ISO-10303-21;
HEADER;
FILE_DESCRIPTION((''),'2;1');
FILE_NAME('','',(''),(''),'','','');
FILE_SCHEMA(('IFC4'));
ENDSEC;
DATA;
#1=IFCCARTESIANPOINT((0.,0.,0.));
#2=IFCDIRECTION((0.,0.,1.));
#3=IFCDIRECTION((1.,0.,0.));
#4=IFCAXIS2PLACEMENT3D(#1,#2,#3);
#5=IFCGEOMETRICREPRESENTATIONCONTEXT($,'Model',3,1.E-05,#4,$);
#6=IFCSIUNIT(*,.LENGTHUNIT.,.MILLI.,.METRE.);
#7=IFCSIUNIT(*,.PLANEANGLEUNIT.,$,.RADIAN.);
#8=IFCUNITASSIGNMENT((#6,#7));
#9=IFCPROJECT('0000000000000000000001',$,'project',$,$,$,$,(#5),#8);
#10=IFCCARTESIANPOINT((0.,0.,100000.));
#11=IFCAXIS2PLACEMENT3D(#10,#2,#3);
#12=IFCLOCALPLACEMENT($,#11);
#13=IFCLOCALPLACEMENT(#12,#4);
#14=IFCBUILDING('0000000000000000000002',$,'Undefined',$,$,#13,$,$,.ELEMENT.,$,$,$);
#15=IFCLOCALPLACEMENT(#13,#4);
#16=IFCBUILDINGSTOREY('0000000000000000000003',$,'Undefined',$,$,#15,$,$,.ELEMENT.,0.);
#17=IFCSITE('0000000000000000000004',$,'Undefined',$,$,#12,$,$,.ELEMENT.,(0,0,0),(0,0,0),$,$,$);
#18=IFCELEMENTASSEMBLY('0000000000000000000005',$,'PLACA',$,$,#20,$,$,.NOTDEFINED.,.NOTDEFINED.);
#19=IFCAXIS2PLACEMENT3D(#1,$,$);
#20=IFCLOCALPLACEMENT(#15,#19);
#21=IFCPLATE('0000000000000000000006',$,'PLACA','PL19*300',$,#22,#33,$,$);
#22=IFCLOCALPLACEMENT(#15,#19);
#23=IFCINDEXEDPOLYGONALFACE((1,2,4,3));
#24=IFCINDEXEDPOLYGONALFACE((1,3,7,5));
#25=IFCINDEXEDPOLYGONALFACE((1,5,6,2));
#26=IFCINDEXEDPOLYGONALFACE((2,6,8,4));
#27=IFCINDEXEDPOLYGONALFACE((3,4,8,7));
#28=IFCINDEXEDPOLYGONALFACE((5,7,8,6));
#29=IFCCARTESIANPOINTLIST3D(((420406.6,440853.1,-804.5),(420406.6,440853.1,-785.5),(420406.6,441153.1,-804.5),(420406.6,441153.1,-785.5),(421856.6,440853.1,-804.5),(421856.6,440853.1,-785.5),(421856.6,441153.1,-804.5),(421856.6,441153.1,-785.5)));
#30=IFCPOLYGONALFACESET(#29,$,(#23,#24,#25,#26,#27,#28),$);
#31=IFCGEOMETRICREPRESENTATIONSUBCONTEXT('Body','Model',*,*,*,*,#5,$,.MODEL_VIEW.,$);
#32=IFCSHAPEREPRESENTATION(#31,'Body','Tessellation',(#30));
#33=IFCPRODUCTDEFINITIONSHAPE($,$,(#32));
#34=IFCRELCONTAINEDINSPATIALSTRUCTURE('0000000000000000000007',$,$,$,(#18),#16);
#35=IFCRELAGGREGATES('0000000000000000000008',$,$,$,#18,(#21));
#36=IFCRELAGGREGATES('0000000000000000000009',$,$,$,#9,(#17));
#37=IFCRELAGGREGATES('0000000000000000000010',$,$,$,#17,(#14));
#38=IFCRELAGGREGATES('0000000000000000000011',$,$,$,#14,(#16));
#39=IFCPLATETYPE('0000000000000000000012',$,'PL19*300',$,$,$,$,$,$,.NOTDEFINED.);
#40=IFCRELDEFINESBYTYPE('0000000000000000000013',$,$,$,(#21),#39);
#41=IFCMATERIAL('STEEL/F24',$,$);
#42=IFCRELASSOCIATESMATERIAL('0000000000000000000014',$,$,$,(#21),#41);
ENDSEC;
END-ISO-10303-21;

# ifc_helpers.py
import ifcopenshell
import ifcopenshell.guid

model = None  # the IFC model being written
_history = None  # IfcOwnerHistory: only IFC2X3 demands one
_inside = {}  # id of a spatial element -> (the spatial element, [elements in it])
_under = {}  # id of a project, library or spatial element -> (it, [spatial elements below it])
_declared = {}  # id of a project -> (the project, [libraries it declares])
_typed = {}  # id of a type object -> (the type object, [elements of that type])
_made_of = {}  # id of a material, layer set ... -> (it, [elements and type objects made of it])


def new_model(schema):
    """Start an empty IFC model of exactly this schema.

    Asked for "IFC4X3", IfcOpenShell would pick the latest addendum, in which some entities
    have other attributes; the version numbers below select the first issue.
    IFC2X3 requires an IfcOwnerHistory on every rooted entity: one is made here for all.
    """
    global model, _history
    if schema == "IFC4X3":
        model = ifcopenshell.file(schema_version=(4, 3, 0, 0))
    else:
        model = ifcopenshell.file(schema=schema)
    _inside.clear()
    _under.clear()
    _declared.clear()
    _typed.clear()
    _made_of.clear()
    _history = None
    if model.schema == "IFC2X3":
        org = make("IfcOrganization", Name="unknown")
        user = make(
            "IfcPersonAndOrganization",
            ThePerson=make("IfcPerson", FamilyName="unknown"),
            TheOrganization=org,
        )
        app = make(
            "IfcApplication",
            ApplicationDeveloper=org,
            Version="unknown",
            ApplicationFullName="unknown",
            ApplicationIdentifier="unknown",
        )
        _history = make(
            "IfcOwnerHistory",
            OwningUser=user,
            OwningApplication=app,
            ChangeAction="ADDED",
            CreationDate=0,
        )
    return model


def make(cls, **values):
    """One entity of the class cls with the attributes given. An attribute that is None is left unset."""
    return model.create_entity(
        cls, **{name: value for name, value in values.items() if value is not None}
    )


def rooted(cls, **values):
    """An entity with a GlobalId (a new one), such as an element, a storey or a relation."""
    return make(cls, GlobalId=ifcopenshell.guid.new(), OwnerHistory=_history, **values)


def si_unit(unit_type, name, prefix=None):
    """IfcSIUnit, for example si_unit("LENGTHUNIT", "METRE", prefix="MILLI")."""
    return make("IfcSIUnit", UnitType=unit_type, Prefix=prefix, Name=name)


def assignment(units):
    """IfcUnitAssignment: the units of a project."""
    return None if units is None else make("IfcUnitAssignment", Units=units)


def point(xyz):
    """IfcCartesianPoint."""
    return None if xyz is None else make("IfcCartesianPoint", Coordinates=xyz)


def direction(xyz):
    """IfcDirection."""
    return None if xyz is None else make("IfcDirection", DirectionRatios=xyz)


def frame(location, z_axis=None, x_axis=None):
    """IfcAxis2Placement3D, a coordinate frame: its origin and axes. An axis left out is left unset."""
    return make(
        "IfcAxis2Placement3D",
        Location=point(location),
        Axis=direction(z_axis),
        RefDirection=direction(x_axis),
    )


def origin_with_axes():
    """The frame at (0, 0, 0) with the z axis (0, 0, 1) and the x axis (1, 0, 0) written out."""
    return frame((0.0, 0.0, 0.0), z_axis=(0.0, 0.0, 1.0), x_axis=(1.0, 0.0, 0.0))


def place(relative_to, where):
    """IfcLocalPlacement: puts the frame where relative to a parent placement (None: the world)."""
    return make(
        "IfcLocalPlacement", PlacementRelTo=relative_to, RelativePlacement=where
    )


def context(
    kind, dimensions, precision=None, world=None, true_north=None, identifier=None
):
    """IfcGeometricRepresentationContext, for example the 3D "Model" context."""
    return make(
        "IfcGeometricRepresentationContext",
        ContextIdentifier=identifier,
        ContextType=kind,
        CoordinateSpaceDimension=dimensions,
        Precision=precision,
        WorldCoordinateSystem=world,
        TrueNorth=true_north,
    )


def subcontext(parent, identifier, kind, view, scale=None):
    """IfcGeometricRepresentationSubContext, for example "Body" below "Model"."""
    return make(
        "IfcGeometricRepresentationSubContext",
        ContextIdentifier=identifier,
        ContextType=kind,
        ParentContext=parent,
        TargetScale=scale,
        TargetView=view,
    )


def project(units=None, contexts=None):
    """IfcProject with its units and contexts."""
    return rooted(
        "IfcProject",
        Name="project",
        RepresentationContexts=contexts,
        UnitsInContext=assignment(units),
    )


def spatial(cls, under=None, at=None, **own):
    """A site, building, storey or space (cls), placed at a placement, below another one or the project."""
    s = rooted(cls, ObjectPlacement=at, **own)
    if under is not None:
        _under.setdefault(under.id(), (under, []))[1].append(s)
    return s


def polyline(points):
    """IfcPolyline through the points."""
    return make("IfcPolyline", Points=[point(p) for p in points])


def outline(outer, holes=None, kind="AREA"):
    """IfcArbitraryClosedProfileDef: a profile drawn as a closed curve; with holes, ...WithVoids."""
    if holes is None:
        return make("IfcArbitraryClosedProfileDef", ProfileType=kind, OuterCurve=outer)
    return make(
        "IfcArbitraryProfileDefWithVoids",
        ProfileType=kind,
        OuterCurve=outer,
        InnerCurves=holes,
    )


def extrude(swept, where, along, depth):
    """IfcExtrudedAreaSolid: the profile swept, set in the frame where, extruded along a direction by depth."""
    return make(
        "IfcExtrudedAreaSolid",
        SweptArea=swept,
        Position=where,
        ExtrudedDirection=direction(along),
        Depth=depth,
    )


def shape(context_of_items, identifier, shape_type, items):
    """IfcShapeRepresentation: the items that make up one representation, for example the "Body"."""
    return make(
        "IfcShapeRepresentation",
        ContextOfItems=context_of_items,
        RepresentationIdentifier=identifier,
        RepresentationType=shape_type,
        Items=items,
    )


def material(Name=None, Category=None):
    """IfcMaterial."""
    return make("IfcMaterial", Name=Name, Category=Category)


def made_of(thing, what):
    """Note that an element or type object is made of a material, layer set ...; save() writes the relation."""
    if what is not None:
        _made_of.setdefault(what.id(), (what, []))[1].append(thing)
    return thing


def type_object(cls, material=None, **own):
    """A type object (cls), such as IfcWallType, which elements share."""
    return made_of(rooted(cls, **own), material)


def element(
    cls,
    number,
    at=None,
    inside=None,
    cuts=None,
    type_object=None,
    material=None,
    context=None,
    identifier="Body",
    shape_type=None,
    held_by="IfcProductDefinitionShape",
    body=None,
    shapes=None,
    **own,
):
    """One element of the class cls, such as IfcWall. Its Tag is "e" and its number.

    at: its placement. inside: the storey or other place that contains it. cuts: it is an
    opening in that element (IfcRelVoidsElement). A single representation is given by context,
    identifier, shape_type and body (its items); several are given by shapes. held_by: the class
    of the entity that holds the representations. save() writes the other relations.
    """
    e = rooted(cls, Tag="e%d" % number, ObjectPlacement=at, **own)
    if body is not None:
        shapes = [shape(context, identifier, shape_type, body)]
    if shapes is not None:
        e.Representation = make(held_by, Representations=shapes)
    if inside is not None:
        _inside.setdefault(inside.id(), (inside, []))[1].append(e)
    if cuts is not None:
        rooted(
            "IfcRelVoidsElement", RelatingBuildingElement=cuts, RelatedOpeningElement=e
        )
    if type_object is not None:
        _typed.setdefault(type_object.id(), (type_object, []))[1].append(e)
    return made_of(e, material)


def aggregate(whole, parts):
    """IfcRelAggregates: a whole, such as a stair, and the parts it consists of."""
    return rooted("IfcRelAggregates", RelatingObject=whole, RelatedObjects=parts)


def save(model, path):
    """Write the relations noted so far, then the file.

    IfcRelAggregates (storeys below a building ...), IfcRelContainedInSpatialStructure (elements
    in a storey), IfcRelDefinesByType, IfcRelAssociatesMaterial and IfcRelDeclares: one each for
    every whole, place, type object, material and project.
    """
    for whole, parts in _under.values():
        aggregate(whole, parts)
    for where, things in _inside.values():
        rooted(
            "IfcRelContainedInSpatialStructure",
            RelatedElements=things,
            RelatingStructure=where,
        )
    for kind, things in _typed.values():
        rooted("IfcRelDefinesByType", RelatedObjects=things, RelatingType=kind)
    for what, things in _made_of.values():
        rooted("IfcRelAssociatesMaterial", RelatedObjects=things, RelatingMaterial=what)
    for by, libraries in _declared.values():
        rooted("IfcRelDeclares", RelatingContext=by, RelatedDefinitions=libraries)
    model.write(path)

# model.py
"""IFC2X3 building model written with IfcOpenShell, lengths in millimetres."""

from ifc_helpers import new_model, si_unit, frame, origin_with_axes, place, context, subcontext, project, spatial, polyline, outline, extrude, material, type_object, element, aggregate, save


model = new_model("IFC2X3")

# Units and contexts
model_context = context("Model", 3, precision=1e-05, world=origin_with_axes())
body_context = subcontext(model_context, "Body", "Model", "MODEL_VIEW")
ifc_project = project(units=[si_unit("LENGTHUNIT", "METRE", prefix="MILLI"), si_unit("PLANEANGLEUNIT", "RADIAN")], contexts=[model_context])

# Site, building, storey
site_placement = place(None, frame((0.0, 0.0, 100000.0), z_axis=(0.0, 0.0, 1.0), x_axis=(1.0, 0.0, 0.0)))
site = spatial("IfcSite", under=ifc_project, at=site_placement, Name="Undefined", CompositionType="ELEMENT", RefLatitude=(0, 0, 0), RefLongitude=(0, 0, 0))
building_placement = place(site_placement, origin_with_axes())
building = spatial("IfcBuilding", under=site, at=building_placement, Name="Undefined", CompositionType="ELEMENT")
storey_placement = place(building_placement, origin_with_axes())
storey = spatial("IfcBuildingStorey", under=building, at=storey_placement, Name="Undefined", CompositionType="ELEMENT", Elevation=0.0)

# Shared definitions
ifc_material_1 = material(Name="STEEL/F24")

# Element assembly, plate
assembly_1_placement = place(storey_placement, origin_with_axes())
assembly_1 = element("IfcElementAssembly", 1, at=assembly_1_placement, inside=storey, Name="PLACA", AssemblyPlace="NOTDEFINED", PredefinedType="NOTDEFINED")
plate_type = type_object("IfcPlateType", Name="PL19*300", PredefinedType="NOTDEFINED")
plate_placement = place(assembly_1_placement, frame((421856.6, 441153.1, -795.0), z_axis=(0.0, 0.0, 1.0), x_axis=(-1.0, 0.0, 0.0)))
plate = element("IfcPlate", 2, at=plate_placement, type_object=plate_type, material=ifc_material_1, Name="PLACA", Description="PL19*300", context=body_context, shape_type="SweptSolid", body=[
    extrude(outline(polyline([(0.0, 0.0), (1450.0, 0.0), (1450.0, 300.0), (0.0, 300.0), (0.0, 0.0)])), frame((0.0, 0.0, -9.5), z_axis=(0.0, 0.0, 1.0), x_axis=(1.0, 0.0, 0.0)), (0.0, 0.0, 1.0), 19.0),
])
aggregate(assembly_1, [plate])

save(model, "model.ifc")
